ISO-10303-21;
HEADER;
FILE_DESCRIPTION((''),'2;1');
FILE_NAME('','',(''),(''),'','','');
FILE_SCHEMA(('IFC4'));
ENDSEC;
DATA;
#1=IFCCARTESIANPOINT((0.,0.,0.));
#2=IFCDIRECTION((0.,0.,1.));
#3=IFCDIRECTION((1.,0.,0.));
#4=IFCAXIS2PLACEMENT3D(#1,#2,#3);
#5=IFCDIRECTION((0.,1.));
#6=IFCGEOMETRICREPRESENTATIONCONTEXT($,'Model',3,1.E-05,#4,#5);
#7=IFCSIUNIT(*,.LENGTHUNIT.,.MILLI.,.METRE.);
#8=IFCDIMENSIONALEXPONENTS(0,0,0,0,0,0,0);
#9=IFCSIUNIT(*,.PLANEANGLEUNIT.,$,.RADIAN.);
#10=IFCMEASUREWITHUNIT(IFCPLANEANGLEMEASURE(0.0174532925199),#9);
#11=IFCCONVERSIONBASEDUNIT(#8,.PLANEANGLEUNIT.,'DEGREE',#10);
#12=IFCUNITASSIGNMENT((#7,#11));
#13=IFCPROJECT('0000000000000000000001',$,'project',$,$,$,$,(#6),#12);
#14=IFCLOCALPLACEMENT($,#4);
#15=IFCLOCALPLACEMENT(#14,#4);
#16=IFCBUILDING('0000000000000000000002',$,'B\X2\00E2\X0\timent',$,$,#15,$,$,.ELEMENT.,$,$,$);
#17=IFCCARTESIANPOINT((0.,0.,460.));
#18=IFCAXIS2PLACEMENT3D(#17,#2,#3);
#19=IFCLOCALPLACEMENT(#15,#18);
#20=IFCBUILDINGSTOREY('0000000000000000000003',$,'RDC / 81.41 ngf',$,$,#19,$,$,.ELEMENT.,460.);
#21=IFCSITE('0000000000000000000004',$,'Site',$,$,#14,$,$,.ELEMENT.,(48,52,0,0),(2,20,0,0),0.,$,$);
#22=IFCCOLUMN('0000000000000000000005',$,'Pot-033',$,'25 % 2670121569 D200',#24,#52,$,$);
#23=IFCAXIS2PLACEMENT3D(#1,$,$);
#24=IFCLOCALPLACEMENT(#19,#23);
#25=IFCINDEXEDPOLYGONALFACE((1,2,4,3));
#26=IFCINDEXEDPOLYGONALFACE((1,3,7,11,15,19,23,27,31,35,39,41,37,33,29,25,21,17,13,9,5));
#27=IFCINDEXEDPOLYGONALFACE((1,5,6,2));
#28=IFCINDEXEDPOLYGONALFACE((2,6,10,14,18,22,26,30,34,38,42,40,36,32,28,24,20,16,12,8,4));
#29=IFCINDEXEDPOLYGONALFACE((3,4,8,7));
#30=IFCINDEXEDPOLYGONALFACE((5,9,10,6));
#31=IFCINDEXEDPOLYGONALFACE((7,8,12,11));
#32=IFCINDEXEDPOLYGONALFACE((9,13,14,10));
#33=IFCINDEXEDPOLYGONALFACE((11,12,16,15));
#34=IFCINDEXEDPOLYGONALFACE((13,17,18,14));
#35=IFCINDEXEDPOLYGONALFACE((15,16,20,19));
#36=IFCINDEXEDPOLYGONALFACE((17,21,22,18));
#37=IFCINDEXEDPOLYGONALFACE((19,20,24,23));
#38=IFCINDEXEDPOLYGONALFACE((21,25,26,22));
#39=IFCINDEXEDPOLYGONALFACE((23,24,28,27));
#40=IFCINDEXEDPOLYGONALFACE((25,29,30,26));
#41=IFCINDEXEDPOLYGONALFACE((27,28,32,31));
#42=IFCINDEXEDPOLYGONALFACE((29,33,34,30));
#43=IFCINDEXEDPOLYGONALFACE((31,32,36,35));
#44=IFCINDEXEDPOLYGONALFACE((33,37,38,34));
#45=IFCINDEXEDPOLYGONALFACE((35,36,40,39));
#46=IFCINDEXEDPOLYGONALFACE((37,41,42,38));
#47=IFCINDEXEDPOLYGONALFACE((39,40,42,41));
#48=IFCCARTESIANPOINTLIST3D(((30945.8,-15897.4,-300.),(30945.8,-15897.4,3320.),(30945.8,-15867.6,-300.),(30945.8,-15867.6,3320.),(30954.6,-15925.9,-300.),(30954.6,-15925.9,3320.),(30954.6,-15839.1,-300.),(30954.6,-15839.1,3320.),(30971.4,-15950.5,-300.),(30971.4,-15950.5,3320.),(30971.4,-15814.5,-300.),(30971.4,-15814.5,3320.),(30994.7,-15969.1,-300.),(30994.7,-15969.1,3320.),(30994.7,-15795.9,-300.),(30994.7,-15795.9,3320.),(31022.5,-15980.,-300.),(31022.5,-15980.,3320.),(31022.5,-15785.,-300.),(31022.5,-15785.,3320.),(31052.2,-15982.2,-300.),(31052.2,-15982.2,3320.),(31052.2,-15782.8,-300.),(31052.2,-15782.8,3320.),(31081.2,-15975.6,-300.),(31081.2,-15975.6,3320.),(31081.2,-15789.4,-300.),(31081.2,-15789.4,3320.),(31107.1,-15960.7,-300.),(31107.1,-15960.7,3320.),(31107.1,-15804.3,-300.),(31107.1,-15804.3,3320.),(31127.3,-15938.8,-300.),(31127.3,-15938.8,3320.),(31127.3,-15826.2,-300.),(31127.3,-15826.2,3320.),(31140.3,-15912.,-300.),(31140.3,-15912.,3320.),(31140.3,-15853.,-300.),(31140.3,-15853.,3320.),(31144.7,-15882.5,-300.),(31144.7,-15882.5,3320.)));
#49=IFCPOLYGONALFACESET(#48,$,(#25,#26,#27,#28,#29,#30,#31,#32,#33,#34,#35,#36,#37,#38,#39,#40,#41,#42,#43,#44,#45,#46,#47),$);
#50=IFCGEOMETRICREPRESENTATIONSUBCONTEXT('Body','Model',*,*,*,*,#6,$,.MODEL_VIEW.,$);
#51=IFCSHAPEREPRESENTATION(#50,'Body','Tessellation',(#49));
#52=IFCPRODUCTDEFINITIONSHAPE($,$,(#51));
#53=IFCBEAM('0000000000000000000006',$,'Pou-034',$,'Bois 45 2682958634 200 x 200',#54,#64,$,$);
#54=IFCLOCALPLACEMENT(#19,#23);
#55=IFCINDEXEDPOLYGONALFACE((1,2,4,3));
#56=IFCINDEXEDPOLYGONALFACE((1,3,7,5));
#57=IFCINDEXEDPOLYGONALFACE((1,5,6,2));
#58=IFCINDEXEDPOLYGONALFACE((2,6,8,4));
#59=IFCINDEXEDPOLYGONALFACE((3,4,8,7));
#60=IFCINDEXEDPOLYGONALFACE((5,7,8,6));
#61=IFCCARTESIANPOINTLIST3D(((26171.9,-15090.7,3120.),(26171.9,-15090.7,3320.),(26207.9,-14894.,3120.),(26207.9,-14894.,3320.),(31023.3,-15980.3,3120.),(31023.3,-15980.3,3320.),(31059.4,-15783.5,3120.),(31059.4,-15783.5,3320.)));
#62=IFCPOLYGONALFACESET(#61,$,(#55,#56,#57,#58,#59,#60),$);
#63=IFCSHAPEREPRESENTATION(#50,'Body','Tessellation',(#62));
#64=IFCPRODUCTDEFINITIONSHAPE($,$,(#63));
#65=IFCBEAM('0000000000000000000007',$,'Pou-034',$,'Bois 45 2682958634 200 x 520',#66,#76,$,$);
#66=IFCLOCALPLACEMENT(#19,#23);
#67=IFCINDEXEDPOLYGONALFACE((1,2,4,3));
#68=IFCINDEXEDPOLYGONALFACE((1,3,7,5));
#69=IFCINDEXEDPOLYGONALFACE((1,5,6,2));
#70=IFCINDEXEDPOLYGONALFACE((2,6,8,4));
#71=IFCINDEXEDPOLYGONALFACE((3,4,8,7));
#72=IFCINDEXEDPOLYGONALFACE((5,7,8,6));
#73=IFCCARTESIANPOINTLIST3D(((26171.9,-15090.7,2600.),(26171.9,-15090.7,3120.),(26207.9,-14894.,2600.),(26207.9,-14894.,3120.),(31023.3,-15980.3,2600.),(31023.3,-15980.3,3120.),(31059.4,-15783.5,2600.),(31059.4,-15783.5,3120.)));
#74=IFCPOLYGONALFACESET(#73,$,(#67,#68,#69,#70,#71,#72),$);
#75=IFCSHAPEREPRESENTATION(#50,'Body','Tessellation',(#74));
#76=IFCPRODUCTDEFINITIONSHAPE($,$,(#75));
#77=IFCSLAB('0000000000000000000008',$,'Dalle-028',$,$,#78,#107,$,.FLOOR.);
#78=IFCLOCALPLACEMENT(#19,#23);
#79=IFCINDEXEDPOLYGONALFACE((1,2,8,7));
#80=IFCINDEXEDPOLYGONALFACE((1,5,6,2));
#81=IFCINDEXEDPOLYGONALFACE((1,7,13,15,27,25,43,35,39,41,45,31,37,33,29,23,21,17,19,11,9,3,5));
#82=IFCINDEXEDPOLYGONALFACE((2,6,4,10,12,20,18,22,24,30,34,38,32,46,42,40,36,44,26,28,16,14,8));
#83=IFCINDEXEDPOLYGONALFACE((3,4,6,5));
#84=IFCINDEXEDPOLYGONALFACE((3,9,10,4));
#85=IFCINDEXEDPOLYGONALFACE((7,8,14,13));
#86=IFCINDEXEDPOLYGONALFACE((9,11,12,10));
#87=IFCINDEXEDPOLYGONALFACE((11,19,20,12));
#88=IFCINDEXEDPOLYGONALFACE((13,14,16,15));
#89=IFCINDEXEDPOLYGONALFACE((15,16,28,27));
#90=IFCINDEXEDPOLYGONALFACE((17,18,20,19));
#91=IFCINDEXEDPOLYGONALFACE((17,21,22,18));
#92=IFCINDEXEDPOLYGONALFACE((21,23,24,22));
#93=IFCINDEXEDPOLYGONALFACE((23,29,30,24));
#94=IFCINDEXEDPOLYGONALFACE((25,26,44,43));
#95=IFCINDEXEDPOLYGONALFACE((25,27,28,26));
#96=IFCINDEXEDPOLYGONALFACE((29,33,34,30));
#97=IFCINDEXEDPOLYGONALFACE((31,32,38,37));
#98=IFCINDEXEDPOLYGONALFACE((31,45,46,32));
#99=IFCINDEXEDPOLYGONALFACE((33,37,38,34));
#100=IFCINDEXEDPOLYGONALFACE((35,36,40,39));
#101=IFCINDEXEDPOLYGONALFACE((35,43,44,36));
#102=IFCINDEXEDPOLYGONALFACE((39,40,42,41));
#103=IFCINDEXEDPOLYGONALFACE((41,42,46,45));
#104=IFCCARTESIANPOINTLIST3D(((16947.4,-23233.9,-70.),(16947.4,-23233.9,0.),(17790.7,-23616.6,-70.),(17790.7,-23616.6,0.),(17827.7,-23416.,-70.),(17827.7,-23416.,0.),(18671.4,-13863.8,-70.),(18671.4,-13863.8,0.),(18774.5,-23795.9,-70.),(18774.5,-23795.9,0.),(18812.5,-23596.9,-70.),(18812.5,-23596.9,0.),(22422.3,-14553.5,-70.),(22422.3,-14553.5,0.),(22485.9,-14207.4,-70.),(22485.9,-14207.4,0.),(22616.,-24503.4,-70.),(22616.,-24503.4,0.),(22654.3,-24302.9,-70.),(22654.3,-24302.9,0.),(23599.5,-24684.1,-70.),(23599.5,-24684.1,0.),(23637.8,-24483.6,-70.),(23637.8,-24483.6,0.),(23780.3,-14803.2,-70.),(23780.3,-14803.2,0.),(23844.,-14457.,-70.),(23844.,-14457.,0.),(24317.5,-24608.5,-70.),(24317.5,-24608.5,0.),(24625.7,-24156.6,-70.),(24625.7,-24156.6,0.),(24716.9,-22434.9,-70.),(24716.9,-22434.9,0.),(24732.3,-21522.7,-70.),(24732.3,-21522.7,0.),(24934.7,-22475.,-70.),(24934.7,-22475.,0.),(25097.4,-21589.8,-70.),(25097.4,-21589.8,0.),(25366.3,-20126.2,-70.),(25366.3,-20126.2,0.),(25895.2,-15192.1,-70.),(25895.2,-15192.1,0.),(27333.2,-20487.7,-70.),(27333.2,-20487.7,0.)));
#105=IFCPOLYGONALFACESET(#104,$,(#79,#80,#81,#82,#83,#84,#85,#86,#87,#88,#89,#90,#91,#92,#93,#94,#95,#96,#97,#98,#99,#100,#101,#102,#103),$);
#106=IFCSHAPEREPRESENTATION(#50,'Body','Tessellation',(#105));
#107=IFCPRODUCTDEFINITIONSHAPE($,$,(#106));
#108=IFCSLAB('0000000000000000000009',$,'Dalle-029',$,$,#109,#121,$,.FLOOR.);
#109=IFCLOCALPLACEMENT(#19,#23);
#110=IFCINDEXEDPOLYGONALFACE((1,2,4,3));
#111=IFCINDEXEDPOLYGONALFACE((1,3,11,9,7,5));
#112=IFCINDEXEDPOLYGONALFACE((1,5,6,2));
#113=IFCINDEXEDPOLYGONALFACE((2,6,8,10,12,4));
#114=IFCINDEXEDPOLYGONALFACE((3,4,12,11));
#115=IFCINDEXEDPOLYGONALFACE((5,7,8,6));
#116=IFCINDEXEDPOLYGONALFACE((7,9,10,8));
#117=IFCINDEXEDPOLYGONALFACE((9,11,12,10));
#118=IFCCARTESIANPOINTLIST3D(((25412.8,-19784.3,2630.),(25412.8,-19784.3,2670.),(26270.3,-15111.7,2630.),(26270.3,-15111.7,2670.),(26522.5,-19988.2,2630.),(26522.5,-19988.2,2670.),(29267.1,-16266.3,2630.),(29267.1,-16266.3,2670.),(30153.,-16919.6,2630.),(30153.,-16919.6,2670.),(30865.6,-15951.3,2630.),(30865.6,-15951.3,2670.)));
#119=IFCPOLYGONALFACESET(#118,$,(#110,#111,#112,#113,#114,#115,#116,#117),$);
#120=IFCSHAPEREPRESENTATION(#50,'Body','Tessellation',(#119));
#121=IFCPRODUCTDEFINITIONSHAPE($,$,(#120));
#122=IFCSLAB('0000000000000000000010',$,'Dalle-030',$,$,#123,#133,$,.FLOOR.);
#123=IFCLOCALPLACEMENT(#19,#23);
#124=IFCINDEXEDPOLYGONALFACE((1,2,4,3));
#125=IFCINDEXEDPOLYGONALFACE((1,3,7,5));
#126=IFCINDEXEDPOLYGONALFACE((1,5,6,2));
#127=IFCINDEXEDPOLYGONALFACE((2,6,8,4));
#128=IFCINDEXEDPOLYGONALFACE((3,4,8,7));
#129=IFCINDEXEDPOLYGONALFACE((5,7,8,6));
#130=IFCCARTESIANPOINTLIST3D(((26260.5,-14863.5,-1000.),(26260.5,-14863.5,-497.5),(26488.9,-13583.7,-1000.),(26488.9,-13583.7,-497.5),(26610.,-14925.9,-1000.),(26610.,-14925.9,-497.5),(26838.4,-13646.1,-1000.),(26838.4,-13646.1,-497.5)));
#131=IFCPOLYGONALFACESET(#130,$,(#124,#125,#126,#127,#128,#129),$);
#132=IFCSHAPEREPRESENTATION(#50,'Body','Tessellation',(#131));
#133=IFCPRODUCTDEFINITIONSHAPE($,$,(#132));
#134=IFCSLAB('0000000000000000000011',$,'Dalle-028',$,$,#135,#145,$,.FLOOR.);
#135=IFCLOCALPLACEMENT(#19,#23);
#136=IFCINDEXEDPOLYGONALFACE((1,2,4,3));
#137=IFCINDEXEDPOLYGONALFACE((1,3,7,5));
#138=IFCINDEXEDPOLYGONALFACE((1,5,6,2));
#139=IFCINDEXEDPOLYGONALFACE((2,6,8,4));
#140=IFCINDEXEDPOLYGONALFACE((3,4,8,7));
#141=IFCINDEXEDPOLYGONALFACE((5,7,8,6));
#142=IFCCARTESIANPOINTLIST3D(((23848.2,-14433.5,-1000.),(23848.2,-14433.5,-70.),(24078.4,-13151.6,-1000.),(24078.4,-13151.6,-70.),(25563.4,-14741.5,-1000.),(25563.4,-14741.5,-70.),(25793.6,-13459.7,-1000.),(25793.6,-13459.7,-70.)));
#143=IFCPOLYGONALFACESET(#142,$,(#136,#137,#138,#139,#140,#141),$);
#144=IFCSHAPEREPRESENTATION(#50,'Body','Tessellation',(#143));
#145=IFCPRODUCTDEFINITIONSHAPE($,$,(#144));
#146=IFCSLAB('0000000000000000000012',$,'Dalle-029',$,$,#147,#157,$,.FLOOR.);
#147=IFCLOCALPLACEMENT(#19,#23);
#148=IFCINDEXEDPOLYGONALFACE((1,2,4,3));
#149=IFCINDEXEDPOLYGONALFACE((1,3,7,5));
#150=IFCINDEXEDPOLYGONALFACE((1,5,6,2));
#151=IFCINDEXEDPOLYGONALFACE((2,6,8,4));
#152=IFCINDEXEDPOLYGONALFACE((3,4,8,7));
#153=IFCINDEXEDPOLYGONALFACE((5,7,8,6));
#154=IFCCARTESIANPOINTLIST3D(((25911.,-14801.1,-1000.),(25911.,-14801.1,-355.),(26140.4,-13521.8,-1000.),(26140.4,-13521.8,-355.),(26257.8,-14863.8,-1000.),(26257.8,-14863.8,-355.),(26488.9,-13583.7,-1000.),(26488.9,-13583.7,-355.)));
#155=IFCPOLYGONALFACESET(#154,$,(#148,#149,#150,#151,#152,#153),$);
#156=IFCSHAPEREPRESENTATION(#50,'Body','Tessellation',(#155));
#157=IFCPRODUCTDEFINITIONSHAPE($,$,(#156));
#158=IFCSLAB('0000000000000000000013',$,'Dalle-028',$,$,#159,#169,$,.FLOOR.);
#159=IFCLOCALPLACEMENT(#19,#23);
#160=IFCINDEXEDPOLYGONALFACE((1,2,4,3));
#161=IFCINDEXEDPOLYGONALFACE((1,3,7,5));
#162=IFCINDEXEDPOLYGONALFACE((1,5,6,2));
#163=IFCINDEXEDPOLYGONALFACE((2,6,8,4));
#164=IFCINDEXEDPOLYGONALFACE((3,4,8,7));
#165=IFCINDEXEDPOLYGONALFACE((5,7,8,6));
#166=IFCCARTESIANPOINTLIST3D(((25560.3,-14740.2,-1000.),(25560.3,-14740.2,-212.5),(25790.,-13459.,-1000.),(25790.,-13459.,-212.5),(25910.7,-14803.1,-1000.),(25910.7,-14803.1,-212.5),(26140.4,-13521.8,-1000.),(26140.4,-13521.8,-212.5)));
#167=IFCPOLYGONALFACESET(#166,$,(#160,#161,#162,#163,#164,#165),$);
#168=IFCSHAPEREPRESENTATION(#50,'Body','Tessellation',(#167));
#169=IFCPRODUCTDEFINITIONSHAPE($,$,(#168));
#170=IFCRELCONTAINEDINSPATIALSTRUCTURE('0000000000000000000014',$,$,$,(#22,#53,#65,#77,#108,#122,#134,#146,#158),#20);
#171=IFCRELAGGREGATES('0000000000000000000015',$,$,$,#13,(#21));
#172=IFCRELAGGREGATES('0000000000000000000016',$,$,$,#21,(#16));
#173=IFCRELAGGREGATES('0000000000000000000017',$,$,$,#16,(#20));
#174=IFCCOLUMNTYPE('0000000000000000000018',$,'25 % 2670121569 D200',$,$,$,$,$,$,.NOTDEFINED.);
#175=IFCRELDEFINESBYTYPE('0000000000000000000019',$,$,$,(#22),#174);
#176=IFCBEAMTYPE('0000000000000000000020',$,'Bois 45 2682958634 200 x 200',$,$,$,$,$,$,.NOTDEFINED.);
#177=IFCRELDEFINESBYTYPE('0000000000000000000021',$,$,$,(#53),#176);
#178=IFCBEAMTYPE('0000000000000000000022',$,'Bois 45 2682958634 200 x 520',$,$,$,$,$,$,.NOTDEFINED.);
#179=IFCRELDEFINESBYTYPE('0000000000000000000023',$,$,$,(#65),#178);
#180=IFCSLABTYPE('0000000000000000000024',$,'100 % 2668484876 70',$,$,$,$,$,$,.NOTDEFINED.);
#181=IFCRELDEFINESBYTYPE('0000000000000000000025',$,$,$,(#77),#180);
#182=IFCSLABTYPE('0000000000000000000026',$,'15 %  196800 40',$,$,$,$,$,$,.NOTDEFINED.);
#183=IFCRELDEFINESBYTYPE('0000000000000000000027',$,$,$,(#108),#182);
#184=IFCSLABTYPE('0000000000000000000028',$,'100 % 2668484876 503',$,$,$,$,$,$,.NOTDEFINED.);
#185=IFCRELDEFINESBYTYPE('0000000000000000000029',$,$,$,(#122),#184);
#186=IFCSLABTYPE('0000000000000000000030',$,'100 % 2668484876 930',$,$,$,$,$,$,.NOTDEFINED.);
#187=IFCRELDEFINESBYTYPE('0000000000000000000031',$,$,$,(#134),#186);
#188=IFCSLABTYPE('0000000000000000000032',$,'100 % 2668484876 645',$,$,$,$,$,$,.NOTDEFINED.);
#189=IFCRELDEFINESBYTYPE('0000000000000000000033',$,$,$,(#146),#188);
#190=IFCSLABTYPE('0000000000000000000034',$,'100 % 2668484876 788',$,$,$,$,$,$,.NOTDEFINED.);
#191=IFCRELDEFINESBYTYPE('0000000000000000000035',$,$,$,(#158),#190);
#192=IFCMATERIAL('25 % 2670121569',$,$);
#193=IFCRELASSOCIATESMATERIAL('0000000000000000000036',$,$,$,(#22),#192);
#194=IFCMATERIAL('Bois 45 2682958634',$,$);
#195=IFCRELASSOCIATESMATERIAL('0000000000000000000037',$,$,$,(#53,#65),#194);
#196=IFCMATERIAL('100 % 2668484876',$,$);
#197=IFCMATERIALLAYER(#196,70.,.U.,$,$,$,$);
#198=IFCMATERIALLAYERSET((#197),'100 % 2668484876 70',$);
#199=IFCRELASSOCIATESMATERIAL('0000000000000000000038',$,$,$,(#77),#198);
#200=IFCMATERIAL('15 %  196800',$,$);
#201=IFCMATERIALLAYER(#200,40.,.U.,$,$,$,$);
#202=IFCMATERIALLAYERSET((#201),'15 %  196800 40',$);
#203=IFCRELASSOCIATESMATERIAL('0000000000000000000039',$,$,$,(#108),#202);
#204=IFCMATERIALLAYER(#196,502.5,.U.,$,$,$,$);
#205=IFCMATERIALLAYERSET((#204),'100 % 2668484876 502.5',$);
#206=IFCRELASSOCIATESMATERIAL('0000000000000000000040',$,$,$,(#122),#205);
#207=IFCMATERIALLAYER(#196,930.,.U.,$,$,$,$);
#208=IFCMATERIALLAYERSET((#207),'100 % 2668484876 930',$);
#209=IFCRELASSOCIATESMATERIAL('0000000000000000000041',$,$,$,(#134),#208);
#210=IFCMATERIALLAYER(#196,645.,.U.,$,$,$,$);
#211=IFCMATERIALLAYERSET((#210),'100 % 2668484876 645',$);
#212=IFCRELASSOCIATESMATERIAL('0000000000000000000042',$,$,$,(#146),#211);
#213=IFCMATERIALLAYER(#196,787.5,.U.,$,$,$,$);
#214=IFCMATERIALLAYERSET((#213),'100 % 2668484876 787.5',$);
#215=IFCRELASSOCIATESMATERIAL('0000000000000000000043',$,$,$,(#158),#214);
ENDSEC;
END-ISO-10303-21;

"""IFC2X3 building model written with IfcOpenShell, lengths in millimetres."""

from ifc_helpers import new_model, entity, si_unit, converted_unit, direction, frame, frame_2d, origin_with_axes, origin_2d_with_axis, place, context, subcontext, project, spatial, polyline, rectangle, circle, outline, extrude, material, layer, layer_set, layer_usage, type_object, element, save


model = new_model("IFC2X3")

# Units and contexts
model_context = context("Model", 3, precision=1e-05, world=origin_with_axes(), true_north=direction((0.0, 1.0)))
body_context = subcontext(model_context, "Body", "Model", "MODEL_VIEW")
ifc_project = project(units=[si_unit("LENGTHUNIT", "METRE", prefix="MILLI"), converted_unit("PLANEANGLEUNIT", "DEGREE", entity("IfcPlaneAngleMeasure", 0.0174532925199), si_unit("PLANEANGLEUNIT", "RADIAN"), dimensions=[0, 0, 0, 0, 0, 0, 0])], contexts=[model_context])

# Site, building, storey
site_placement = place(None, origin_with_axes())
site = spatial("IfcSite", under=ifc_project, at=site_placement, Name="Site", CompositionType="ELEMENT", RefLatitude=(48, 52, 0, 0), RefLongitude=(2, 20, 0, 0), RefElevation=0.0)
building_placement = place(site_placement, origin_with_axes())
building = spatial("IfcBuilding", under=site, at=building_placement, Name="Bâtiment", CompositionType="ELEMENT")
storey_placement = place(building_placement, frame((0.0, 0.0, 460.0), z_axis=(0.0, 0.0, 1.0), x_axis=(1.0, 0.0, 0.0)))
storey = spatial("IfcBuildingStorey", under=building, at=storey_placement, Name="RDC / 81.41 ngf", CompositionType="ELEMENT", Elevation=460.0)

# Column
ifc_material_1 = material(Name="25 % 2670121569")
column_type = type_object("IfcColumnType", Name="25 % 2670121569 D200", PredefinedType="NOTDEFINED")
column_placement = place(storey_placement, frame((31044.7, -15882.5, -300.0), z_axis=(0.0, 0.0, 1.0), x_axis=(1.0, 0.0, 0.0)))
element("IfcColumn", 1, at=column_placement, inside=storey, type_object=column_type, material=ifc_material_1, Name="Pot-033", ObjectType="25 % 2670121569 D200", context=body_context, shape_type="SweptSolid", body=[
    extrude(circle(Radius=100.0, at=origin_2d_with_axis()), origin_with_axes(), (0.0, 0.0, 1.0), 3620.0),
])

# Beams
ifc_material_2 = material(Name="Bois 45 2682958634")
beam_type_1 = type_object("IfcBeamType", Name="Bois 45 2682958634 200 x 200", PredefinedType="NOTDEFINED")
beam_1_placement = place(storey_placement, frame((26189.9, -14992.4, 3320.0), z_axis=(0.0, 0.0, 1.0), x_axis=(-0.180344, -0.983604, 0.0)))
element("IfcBeam", 2, at=beam_1_placement, inside=storey, type_object=beam_type_1, material=ifc_material_2, Name="Pou-034", ObjectType="Bois 45 2682958634 200 x 200", context=body_context, shape_type="SweptSolid", body=[
    extrude(rectangle(XDim=200.0, YDim=200.0, at=frame_2d((-100.0, 0.0), x_axis=(1.0, 0.0))), frame((0.0, 0.0, 0.0), z_axis=(0.0, 1.0, 0.0), x_axis=(0.0, 0.0, 1.0)), (0.0, 0.0, 1.0), 4932.3),
])
beam_type_2 = type_object("IfcBeamType", Name="Bois 45 2682958634 200 x 520", PredefinedType="NOTDEFINED")
beam_2_placement = place(storey_placement, frame((26189.9, -14992.4, 3120.0), z_axis=(0.0, 0.0, 1.0), x_axis=(-0.180344, -0.983604, 0.0)))
element("IfcBeam", 3, at=beam_2_placement, inside=storey, type_object=beam_type_2, material=ifc_material_2, Name="Pou-034", ObjectType="Bois 45 2682958634 200 x 520", context=body_context, shape_type="SweptSolid", body=[
    extrude(rectangle(XDim=520.0, YDim=200.0, at=frame_2d((-260.0, 0.0), x_axis=(1.0, 0.0))), frame((0.0, 0.0, 0.0), z_axis=(0.0, 1.0, 0.0), x_axis=(0.0, 0.0, 1.0)), (0.0, 0.0, 1.0), 4932.3),
])

# Slabs
ifc_material_3 = material(Name="100 % 2668484876")
ifc_layer_1 = layer(ifc_material_3, 70.0, ventilated="UNKNOWN")
ifc_layer_set_1 = layer_set([ifc_layer_1], Name="100 % 2668484876 70")
ifc_layer_usage_1 = layer_usage(ifc_layer_set_1, "AXIS3", "NEGATIVE", 70.0)
slab_type_1 = type_object("IfcSlabType", Name="100 % 2668484876 70", PredefinedType="NOTDEFINED")
slab_1_placement = place(storey_placement, frame((18671.4, -13863.8, 0.0), z_axis=(0.0, 0.0, 1.0), x_axis=(1.0, 0.0, 0.0)))
element("IfcSlab", 4, at=slab_1_placement, inside=storey, type_object=slab_type_1, material=ifc_layer_usage_1, Name="Dalle-028", PredefinedType="FLOOR", context=body_context, shape_type="SweptSolid", body=[
    extrude(outline(polyline([(0.0, 0.0), (-1724.0, -9370.1), (-843.7, -9552.2), (-880.6, -9752.9), (103.1, -9932.2), (141.1, -9733.2), (3982.9, -10439.1), (3944.6, -10639.6), (4928.2, -10820.3), (4966.4, -10619.9), (5646.1, -10744.7), (6045.5, -8571.2), (6263.3, -8611.2), (5954.3, -10292.8), (8661.8, -6623.9), (6694.9, -6262.4), (6426.0, -7726.0), (6060.9, -7658.9), (7223.8, -1328.4), (5108.9, -939.5), (5172.6, -593.3), (3814.5, -343.6), (3750.9, -689.7), (0.0, 0.0)])), frame((0.0, 0.0, -70.0), z_axis=(0.0, 0.0, 1.0), x_axis=(1.0, 0.0, 0.0)), (0.0, 0.0, 1.0), 70.0),
])
ifc_material_4 = material(Name="15 %  196800")
ifc_layer_2 = layer(ifc_material_4, 40.0, ventilated="UNKNOWN")
ifc_layer_set_2 = layer_set([ifc_layer_2], Name="15 %  196800 40")
ifc_layer_usage_2 = layer_usage(ifc_layer_set_2, "AXIS3", "NEGATIVE", 40.0)
slab_type_2 = type_object("IfcSlabType", Name="15 %  196800 40", PredefinedType="NOTDEFINED")
slab_2_placement = place(storey_placement, frame((25412.8, -19784.3, 2670.0), z_axis=(0.0, 0.0, 1.0), x_axis=(1.0, 0.0, 0.0)))
element("IfcSlab", 5, at=slab_2_placement, inside=storey, type_object=slab_type_2, material=ifc_layer_usage_2, Name="Dalle-029", PredefinedType="FLOOR", context=body_context, shape_type="SweptSolid", body=[
    extrude(outline(polyline([(0.0, 0.0), (1109.6, -203.9), (3854.2, 3517.9), (4740.2, 2864.6), (5452.8, 3832.9), (857.5, 4672.6), (0.0, 0.0)])), frame((0.0, 0.0, -40.0), z_axis=(0.0, 0.0, 1.0), x_axis=(1.0, 0.0, 0.0)), (0.0, 0.0, 1.0), 40.0),
])
ifc_layer_3 = layer(ifc_material_3, 502.5, ventilated="UNKNOWN")
ifc_layer_set_3 = layer_set([ifc_layer_3], Name="100 % 2668484876 502.5")
ifc_layer_usage_3 = layer_usage(ifc_layer_set_3, "AXIS3", "NEGATIVE", 502.5)
slab_type_3 = type_object("IfcSlabType", Name="100 % 2668484876 503", PredefinedType="NOTDEFINED")
slab_3_placement = place(storey_placement, frame((26488.9, -13583.7, -497.5), z_axis=(0.0, 0.0, 1.0), x_axis=(1.0, 0.0, 0.0)))
element("IfcSlab", 6, at=slab_3_placement, inside=storey, type_object=slab_type_3, material=ifc_layer_usage_3, Name="Dalle-030", PredefinedType="FLOOR", context=body_context, shape_type="SweptSolid", body=[
    extrude(outline(polyline([(0.0, 0.0), (-228.4, -1279.8), (121.1, -1342.2), (349.5, -62.4), (0.0, 0.0)])), frame((0.0, 0.0, -502.5), z_axis=(0.0, 0.0, 1.0), x_axis=(1.0, 0.0, 0.0)), (0.0, 0.0, 1.0), 502.5),
])
ifc_layer_4 = layer(ifc_material_3, 930.0, ventilated="UNKNOWN")
ifc_layer_set_4 = layer_set([ifc_layer_4], Name="100 % 2668484876 930")
ifc_layer_usage_4 = layer_usage(ifc_layer_set_4, "AXIS3", "NEGATIVE", 930.0)
slab_type_4 = type_object("IfcSlabType", Name="100 % 2668484876 930", PredefinedType="NOTDEFINED")
slab_4_placement = place(storey_placement, frame((24078.4, -13151.6, -70.0), z_axis=(0.0, 0.0, 1.0), x_axis=(1.0, 0.0, 0.0)))
element("IfcSlab", 7, at=slab_4_placement, inside=storey, type_object=slab_type_4, material=ifc_layer_usage_4, Name="Dalle-028", PredefinedType="FLOOR", context=body_context, shape_type="SweptSolid", body=[
    extrude(outline(polyline([(0.0, 0.0), (-230.2, -1281.9), (1484.9, -1589.9), (1715.2, -308.1), (0.0, 0.0)])), frame((0.0, 0.0, -930.0), z_axis=(0.0, 0.0, 1.0), x_axis=(1.0, 0.0, 0.0)), (0.0, 0.0, 1.0), 930.0),
])
ifc_layer_5 = layer(ifc_material_3, 645.0, ventilated="UNKNOWN")
ifc_layer_set_5 = layer_set([ifc_layer_5], Name="100 % 2668484876 645")
ifc_layer_usage_5 = layer_usage(ifc_layer_set_5, "AXIS3", "NEGATIVE", 645.0)
slab_type_5 = type_object("IfcSlabType", Name="100 % 2668484876 645", PredefinedType="NOTDEFINED")
slab_5_placement = place(storey_placement, frame((25911.0, -14801.1, -355.0), z_axis=(0.0, 0.0, 1.0), x_axis=(1.0, 0.0, 0.0)))
element("IfcSlab", 8, at=slab_5_placement, inside=storey, type_object=slab_type_5, material=ifc_layer_usage_5, Name="Dalle-029", PredefinedType="FLOOR", context=body_context, shape_type="SweptSolid", body=[
    extrude(outline(polyline([(0.0, 0.0), (346.8, -62.6), (577.9, 1217.4), (229.4, 1279.3), (0.0, 0.0)])), frame((0.0, 0.0, -645.0), z_axis=(0.0, 0.0, 1.0), x_axis=(1.0, 0.0, 0.0)), (0.0, 0.0, 1.0), 645.0),
])
ifc_layer_6 = layer(ifc_material_3, 787.5, ventilated="UNKNOWN")
ifc_layer_set_6 = layer_set([ifc_layer_6], Name="100 % 2668484876 787.5")
ifc_layer_usage_6 = layer_usage(ifc_layer_set_6, "AXIS3", "NEGATIVE", 787.5)
slab_type_6 = type_object("IfcSlabType", Name="100 % 2668484876 788", PredefinedType="NOTDEFINED")
slab_6_placement = place(storey_placement, frame((25790.0, -13459.0, -212.5), z_axis=(0.0, 0.0, 1.0), x_axis=(1.0, 0.0, 0.0)))
element("IfcSlab", 9, at=slab_6_placement, inside=storey, type_object=slab_type_6, material=ifc_layer_usage_6, Name="Dalle-028", PredefinedType="FLOOR", context=body_context, shape_type="SweptSolid", body=[
    extrude(outline(polyline([(0.0, 0.0), (-229.7, -1281.2), (120.7, -1344.1), (350.4, -62.8), (0.0, 0.0)])), frame((0.0, 0.0, -787.5), z_axis=(0.0, 0.0, 1.0), x_axis=(1.0, 0.0, 0.0)), (0.0, 0.0, 1.0), 787.5),
])

save(model, "model.ifc")
